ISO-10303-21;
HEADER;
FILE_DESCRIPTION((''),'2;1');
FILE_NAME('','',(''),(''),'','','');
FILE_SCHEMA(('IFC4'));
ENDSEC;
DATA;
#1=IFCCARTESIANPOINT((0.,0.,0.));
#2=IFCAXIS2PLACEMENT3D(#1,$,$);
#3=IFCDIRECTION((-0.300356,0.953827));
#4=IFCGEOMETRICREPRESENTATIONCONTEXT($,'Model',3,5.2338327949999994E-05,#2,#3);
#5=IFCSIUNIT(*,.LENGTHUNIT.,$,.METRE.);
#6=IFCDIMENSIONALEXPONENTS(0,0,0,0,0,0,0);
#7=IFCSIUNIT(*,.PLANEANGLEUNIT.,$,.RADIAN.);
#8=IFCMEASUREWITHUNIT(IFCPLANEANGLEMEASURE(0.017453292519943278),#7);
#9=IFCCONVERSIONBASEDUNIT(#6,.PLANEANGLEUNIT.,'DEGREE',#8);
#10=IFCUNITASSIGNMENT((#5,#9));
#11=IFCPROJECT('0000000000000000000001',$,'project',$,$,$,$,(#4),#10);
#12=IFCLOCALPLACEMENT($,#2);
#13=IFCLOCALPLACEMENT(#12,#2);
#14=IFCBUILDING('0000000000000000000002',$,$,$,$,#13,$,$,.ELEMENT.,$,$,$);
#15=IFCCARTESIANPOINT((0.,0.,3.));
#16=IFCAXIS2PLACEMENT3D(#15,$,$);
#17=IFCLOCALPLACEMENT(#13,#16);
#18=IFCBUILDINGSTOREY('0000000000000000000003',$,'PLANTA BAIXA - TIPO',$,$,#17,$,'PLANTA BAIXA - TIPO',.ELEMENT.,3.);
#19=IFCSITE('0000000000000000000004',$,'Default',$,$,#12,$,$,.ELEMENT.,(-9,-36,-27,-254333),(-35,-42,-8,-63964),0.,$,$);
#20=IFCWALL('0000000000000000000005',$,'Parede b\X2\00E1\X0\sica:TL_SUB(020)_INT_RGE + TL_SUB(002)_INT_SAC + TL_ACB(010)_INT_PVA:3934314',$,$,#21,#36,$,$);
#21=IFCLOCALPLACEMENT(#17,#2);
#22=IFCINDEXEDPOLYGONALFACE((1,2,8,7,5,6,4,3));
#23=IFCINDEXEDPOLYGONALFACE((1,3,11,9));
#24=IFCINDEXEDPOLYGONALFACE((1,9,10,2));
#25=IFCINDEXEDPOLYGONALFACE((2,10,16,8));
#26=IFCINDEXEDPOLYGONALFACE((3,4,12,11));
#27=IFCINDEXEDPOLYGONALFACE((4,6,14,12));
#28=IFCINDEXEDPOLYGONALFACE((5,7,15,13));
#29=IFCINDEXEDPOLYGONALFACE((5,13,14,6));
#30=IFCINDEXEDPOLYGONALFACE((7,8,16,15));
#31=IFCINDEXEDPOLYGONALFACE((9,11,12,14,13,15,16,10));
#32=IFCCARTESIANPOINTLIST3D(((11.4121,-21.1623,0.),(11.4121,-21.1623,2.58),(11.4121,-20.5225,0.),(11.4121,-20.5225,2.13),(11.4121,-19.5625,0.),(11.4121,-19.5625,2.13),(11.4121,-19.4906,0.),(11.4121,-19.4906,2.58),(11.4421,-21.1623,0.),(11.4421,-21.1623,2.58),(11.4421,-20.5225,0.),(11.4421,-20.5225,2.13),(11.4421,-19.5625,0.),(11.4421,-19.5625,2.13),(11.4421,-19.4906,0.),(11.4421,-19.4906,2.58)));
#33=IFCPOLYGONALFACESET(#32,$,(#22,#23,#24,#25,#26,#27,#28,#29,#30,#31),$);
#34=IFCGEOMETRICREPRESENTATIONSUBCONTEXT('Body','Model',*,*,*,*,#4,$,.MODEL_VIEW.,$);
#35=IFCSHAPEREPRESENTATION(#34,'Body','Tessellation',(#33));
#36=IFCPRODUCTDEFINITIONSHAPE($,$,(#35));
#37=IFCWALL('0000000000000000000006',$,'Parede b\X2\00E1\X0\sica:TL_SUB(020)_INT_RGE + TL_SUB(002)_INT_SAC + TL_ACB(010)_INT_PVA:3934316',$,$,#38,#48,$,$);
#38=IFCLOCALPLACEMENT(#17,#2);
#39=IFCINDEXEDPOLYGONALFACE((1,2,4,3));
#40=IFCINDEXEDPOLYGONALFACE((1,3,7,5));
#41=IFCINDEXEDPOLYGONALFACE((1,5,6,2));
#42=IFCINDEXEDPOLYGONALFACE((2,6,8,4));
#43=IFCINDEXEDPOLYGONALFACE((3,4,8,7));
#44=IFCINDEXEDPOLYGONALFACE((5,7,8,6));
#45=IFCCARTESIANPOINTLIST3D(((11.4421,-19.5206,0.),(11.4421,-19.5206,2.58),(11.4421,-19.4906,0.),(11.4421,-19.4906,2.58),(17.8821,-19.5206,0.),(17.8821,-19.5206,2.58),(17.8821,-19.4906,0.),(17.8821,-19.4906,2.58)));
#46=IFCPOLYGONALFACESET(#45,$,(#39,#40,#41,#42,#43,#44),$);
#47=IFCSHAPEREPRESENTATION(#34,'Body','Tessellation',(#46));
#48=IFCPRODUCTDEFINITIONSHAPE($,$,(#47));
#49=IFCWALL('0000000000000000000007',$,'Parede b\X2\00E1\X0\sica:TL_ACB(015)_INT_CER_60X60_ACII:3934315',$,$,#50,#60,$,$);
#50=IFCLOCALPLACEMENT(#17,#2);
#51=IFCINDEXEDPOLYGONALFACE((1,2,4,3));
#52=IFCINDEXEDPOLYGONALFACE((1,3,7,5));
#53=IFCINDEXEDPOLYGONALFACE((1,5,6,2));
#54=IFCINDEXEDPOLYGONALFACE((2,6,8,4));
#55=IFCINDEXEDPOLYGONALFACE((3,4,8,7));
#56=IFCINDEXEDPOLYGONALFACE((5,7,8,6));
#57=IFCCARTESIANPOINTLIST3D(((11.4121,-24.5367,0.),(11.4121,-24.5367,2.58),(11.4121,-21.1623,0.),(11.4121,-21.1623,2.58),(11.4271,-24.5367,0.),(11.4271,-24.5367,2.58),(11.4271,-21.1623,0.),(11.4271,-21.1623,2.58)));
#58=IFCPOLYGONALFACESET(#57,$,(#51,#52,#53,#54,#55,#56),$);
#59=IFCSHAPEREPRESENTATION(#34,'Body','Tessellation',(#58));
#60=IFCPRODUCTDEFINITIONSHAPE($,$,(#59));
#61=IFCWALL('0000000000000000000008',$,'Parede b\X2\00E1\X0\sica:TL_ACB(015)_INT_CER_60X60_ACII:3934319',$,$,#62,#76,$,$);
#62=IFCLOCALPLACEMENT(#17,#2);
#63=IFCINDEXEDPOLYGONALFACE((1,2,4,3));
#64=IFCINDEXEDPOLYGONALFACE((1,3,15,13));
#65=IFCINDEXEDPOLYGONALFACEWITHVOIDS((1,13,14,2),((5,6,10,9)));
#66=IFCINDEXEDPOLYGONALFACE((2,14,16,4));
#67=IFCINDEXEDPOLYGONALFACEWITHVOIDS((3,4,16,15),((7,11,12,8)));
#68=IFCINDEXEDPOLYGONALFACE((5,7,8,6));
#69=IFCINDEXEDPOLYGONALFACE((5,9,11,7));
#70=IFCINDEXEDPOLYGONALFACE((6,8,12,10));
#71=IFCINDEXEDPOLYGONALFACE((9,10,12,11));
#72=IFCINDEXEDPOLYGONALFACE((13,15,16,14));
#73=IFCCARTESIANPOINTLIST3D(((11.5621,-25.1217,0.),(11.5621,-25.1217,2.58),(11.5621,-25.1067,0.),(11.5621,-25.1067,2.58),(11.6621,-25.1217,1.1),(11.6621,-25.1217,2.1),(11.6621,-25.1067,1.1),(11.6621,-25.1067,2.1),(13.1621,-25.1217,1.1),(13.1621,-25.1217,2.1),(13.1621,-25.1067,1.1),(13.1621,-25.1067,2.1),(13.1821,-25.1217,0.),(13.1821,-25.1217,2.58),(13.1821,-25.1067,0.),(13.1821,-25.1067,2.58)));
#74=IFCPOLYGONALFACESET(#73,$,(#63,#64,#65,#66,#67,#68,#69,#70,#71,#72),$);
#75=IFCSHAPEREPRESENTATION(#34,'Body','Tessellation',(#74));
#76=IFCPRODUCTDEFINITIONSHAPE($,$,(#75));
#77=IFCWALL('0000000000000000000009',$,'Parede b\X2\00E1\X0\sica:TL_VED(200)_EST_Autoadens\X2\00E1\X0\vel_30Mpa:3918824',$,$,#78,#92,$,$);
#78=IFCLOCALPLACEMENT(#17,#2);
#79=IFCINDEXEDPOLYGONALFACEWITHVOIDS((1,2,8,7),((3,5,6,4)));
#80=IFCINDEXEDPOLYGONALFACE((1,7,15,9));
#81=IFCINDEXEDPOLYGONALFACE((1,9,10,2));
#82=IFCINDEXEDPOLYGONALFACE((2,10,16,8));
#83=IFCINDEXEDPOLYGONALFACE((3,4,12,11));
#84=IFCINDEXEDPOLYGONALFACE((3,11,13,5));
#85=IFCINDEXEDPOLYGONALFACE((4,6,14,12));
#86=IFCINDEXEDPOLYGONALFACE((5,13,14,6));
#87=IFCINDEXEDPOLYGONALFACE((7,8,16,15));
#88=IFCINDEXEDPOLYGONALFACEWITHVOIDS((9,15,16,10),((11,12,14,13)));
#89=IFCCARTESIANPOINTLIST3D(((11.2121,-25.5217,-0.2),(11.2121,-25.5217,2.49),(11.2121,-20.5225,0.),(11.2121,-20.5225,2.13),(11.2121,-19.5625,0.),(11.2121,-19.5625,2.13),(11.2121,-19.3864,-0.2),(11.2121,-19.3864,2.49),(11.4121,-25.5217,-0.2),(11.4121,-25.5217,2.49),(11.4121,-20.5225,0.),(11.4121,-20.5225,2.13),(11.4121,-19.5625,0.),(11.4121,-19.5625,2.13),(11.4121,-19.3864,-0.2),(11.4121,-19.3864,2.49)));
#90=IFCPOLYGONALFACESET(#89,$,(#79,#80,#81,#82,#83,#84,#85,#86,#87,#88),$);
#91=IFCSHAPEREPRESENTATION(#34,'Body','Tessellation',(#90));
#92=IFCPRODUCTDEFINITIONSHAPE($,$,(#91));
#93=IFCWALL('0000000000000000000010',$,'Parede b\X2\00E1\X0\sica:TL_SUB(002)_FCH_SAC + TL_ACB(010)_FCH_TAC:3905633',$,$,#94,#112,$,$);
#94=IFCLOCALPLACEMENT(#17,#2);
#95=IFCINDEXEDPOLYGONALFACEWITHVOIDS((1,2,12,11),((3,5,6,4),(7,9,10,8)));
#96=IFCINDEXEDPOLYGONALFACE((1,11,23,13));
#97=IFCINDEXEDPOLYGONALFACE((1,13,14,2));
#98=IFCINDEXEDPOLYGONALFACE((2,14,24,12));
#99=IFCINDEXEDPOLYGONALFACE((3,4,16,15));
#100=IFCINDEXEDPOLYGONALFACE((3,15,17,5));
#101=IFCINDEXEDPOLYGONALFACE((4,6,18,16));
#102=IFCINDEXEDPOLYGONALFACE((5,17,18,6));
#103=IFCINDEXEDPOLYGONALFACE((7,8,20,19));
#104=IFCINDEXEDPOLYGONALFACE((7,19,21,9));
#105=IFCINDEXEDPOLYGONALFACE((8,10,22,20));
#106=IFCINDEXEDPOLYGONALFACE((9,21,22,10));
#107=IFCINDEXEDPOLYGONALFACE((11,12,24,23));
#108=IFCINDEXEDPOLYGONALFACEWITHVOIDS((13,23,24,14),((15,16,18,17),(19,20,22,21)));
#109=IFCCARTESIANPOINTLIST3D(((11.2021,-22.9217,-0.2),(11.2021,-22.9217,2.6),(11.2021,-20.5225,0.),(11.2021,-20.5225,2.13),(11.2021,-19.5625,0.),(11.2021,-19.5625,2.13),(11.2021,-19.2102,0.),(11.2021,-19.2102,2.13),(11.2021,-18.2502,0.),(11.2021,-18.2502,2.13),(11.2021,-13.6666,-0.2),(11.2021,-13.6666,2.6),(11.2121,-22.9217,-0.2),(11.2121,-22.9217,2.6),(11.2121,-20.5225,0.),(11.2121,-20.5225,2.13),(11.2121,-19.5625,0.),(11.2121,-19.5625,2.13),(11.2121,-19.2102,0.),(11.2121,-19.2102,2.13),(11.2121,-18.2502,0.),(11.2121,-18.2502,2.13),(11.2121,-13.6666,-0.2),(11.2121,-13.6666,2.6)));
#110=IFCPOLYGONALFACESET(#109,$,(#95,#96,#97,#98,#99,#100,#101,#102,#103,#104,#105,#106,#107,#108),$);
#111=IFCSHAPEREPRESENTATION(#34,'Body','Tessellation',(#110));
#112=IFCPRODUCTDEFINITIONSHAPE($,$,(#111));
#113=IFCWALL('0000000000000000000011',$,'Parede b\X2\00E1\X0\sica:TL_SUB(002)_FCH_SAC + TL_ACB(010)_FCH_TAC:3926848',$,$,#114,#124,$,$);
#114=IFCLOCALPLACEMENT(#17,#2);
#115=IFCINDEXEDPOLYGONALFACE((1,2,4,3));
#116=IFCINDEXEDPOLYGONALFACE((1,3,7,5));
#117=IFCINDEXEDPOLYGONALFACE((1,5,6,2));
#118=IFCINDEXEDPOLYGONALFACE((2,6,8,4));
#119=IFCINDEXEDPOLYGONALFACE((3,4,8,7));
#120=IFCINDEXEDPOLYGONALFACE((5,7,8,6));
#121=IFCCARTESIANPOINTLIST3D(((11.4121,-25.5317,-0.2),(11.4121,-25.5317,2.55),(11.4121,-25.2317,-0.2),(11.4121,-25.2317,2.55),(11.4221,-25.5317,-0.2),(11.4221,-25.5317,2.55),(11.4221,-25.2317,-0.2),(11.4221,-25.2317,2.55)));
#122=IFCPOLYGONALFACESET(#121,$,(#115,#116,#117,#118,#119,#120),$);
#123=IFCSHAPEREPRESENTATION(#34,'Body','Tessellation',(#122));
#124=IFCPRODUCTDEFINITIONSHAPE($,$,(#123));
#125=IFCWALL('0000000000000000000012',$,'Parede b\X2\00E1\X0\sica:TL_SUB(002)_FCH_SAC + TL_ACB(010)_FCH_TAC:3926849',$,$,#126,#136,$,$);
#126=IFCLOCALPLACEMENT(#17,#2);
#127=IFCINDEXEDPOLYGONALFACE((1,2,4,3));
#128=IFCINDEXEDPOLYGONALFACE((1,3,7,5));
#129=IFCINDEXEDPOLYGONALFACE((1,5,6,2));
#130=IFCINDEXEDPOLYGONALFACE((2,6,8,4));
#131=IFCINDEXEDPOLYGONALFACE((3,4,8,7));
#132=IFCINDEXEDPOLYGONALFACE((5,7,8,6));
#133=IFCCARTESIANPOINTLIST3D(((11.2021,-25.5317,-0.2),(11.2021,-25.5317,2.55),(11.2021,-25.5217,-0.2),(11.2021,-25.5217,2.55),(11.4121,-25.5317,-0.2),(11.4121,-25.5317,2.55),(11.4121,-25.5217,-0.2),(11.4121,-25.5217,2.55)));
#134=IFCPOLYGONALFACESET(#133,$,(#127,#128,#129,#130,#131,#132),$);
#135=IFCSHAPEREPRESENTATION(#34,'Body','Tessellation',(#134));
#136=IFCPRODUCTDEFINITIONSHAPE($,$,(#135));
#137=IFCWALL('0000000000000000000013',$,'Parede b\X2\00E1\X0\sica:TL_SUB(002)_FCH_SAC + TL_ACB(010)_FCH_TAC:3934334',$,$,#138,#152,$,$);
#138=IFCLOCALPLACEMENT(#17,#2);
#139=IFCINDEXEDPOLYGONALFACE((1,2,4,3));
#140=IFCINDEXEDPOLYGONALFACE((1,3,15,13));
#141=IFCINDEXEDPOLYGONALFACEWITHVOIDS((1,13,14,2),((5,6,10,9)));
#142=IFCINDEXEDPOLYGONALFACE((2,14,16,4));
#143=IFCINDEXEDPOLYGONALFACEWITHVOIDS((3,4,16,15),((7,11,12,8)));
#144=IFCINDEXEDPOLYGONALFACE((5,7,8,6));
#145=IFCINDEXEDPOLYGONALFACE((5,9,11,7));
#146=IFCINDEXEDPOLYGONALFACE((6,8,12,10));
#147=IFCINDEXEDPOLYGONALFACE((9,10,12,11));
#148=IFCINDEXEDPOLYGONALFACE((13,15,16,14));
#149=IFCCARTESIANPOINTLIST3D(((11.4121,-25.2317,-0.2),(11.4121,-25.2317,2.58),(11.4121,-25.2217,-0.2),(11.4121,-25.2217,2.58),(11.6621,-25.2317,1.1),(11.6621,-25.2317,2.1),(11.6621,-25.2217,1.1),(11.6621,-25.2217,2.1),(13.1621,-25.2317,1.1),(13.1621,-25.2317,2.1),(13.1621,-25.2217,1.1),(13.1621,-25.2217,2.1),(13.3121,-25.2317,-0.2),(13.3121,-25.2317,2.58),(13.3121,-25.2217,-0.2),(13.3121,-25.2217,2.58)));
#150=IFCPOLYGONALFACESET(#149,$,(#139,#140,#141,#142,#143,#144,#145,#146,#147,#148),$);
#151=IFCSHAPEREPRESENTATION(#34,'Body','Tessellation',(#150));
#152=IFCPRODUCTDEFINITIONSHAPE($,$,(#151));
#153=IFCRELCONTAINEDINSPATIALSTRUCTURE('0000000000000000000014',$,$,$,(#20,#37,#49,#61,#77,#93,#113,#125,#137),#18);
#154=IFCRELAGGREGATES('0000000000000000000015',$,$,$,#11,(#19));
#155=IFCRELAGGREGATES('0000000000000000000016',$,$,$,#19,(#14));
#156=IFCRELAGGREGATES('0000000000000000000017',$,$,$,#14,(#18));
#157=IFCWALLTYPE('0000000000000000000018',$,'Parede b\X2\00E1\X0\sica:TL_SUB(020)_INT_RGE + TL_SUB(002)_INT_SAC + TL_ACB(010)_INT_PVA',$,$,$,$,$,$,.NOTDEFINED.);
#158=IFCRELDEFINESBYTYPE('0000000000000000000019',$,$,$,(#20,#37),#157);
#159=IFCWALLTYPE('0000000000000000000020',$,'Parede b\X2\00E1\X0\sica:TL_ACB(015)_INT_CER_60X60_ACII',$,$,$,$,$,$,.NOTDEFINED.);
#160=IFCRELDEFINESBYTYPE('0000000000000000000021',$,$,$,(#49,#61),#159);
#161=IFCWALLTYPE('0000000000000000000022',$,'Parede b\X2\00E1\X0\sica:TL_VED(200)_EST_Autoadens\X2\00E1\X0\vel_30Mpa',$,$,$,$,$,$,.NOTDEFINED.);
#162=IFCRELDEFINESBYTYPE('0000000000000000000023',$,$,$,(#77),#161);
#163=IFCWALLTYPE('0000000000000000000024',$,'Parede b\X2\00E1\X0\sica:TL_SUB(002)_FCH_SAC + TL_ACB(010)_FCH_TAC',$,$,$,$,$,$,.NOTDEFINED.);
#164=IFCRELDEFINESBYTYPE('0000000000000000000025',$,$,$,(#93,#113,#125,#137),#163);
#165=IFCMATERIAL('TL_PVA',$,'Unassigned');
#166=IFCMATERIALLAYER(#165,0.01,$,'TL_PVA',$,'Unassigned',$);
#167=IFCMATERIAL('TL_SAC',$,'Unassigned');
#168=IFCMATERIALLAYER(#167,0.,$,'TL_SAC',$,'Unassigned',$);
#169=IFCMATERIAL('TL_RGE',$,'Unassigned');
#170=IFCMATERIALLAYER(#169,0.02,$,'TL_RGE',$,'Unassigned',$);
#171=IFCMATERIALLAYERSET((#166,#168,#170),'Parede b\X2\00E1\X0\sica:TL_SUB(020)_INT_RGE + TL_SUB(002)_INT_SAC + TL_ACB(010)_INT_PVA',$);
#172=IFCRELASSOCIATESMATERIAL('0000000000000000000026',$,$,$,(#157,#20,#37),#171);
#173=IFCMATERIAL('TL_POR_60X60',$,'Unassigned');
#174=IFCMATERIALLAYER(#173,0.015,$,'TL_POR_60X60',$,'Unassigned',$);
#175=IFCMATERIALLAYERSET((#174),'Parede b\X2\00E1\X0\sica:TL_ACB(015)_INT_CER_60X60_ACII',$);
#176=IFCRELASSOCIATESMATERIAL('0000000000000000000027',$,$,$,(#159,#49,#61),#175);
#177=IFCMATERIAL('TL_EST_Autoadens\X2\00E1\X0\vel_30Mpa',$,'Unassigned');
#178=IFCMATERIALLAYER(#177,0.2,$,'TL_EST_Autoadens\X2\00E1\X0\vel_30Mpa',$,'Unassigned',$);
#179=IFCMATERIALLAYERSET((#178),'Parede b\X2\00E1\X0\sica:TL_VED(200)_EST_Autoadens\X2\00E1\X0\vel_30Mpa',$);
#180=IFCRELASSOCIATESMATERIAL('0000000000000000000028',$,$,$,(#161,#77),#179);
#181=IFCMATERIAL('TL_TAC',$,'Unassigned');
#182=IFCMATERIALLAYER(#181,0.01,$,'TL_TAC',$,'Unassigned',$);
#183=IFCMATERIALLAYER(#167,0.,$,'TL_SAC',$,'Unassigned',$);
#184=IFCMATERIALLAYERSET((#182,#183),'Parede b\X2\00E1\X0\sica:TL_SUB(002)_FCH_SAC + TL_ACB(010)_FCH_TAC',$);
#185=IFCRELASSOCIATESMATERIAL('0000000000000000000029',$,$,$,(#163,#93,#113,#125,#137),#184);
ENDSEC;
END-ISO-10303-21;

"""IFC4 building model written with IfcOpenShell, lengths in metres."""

from ifc_helpers import new_model, entity, si_unit, converted_unit, direction, frame, frame_2d, origin, place, context, subcontext, project, spatial, rectangle, extrude, material, layer, layer_set, layer_usage, type_object, element, save


model = new_model("IFC4")

# Units and contexts
model_context = context("Model", 3, precision=5.2338327949999994e-05, world=origin(), true_north=direction((-0.300356, 0.953827)))
body_context = subcontext(model_context, "Body", "Model", "MODEL_VIEW")
ifc_project = project(units=[si_unit("LENGTHUNIT", "METRE"), converted_unit("PLANEANGLEUNIT", "DEGREE", entity("IfcPlaneAngleMeasure", 0.017453292519943278), si_unit("PLANEANGLEUNIT", "RADIAN"), dimensions=[0, 0, 0, 0, 0, 0, 0])], contexts=[model_context])

# Site, building, storey
site_placement = place(None, origin())
site = spatial("IfcSite", under=ifc_project, at=site_placement, Name="Default", CompositionType="ELEMENT", RefLatitude=(-9, -36, -27, -254333), RefLongitude=(-35, -42, -8, -63964), RefElevation=0.0)
building_placement = place(site_placement, origin())
building = spatial("IfcBuilding", under=site, at=building_placement, CompositionType="ELEMENT")
storey_placement = place(building_placement, frame((0.0, 0.0, 3.0)))
storey = spatial("IfcBuildingStorey", under=building, at=storey_placement, Name="PLANTA BAIXA - TIPO", LongName="PLANTA BAIXA - TIPO", CompositionType="ELEMENT", Elevation=3.0)

# Shared definitions
ifc_material_1 = material(Name="TL_POR_60X60", Category="Unassigned")

# Shared definitions
ifc_material_2 = material(Name="TL_EST_Autoadensável_30Mpa", Category="Unassigned")

# Shared definitions
ifc_material_3 = material(Name="TL_PVA", Category="Unassigned")
ifc_layer_1 = layer(ifc_material_3, 0.01, Name="TL_PVA", Category="Unassigned")
ifc_material_4 = material(Name="TL_SAC", Category="Unassigned")
ifc_layer_2 = layer(ifc_material_4, 0.0, Name="TL_SAC", Category="Unassigned")
ifc_material_5 = material(Name="TL_RGE", Category="Unassigned")
ifc_layer_3 = layer(ifc_material_5, 0.02, Name="TL_RGE", Category="Unassigned")
ifc_layer_set_1 = layer_set([ifc_layer_1, ifc_layer_2, ifc_layer_3], Name="Parede básica:TL_SUB(020)_INT_RGE + TL_SUB(002)_INT_SAC + TL_ACB(010)_INT_PVA")
wall_type_1 = type_object("IfcWallType", Name="Parede básica:TL_SUB(020)_INT_RGE + TL_SUB(002)_INT_SAC + TL_ACB(010)_INT_PVA", PredefinedType="NOTDEFINED", material=ifc_layer_set_1)

# Wall, opening
ifc_layer_usage_1 = layer_usage(ifc_layer_set_1, "AXIS2", "NEGATIVE", 0.015)
wall_1_placement = place(storey_placement, frame((11.4271, -19.4906, 0.0), z_axis=(0.0, 0.0, 1.0), x_axis=(0.0, -1.0, 0.0)))
wall_1 = element("IfcWall", 1, at=wall_1_placement, inside=storey, type_object=wall_type_1, material=ifc_layer_usage_1, Name="Parede básica:TL_SUB(020)_INT_RGE + TL_SUB(002)_INT_SAC + TL_ACB(010)_INT_PVA:3934314", context=body_context, shape_type="SweptSolid", body=[
    extrude(rectangle(XDim=1.6717, YDim=0.03, at=frame_2d((0.8359, 0.0), x_axis=(-1.0, 0.0))), origin(), (0.0, 0.0, 1.0), 2.58),
])
opening_1_placement = place(wall_1_placement, frame((-19.4906, -11.4271, 0.0)))
element("IfcOpeningElement", 2, at=opening_1_placement, cuts=wall_1, PredefinedType="OPENING", context=body_context, shape_type="SweptSolid", body=[
    extrude(rectangle(XDim=2.13, YDim=0.96, at=frame_2d((0.0, 0.0), x_axis=(0.0, 1.0))), frame((20.0425, 9.8881, 1.065), z_axis=(0.0, 1.0, 0.0), x_axis=(-1.0, 0.0, 0.0)), (0.0, 0.0, 1.0), 3.048),
])

# Walls
ifc_layer_usage_2 = layer_usage(ifc_layer_set_1, "AXIS2", "POSITIVE", -0.015)
wall_2_placement = place(storey_placement, frame((11.4421, -19.5056, 0.0)))
element("IfcWall", 3, at=wall_2_placement, inside=storey, type_object=wall_type_1, material=ifc_layer_usage_2, Name="Parede básica:TL_SUB(020)_INT_RGE + TL_SUB(002)_INT_SAC + TL_ACB(010)_INT_PVA:3934316", context=body_context, shape_type="SweptSolid", body=[
    extrude(rectangle(XDim=6.44, YDim=0.03, at=frame_2d((3.22, 0.0), x_axis=(-1.0, 0.0))), origin(), (0.0, 0.0, 1.0), 2.58),
])
ifc_layer_4 = layer(ifc_material_1, 0.015, Name="TL_POR_60X60", Category="Unassigned")
ifc_layer_set_2 = layer_set([ifc_layer_4], Name="Parede básica:TL_ACB(015)_INT_CER_60X60_ACII")
ifc_layer_usage_3 = layer_usage(ifc_layer_set_2, "AXIS2", "NEGATIVE", 0.0075)
wall_type_2 = type_object("IfcWallType", Name="Parede básica:TL_ACB(015)_INT_CER_60X60_ACII", PredefinedType="NOTDEFINED", material=ifc_layer_set_2)
wall_3_placement = place(storey_placement, frame((11.4196, -21.1623, 0.0), z_axis=(0.0, 0.0, 1.0), x_axis=(0.0, -1.0, 0.0)))
element("IfcWall", 4, at=wall_3_placement, inside=storey, type_object=wall_type_2, material=ifc_layer_usage_3, Name="Parede básica:TL_ACB(015)_INT_CER_60X60_ACII:3934315", context=body_context, shape_type="SweptSolid", body=[
    extrude(rectangle(XDim=3.3744, YDim=0.015, at=frame_2d((1.6872, 0.0), x_axis=(-1.0, 0.0))), origin(), (0.0, 0.0, 1.0), 2.58),
])

# Walls, openings
ifc_layer_usage_4 = layer_usage(ifc_layer_set_2, "AXIS2", "NEGATIVE", 0.0075)
wall_4_placement = place(storey_placement, frame((11.5621, -25.1142, 0.0)))
wall_4 = element("IfcWall", 5, at=wall_4_placement, inside=storey, type_object=wall_type_2, material=ifc_layer_usage_4, Name="Parede básica:TL_ACB(015)_INT_CER_60X60_ACII:3934319", context=body_context, shape_type="SweptSolid", body=[
    extrude(rectangle(XDim=1.62, YDim=0.015, at=frame_2d((0.81, 0.0), x_axis=(-1.0, 0.0))), origin(), (0.0, 0.0, 1.0), 2.58),
])
opening_2_placement = place(wall_4_placement, frame((-11.5621, 25.1142, 1.1)))
element("IfcOpeningElement", 6, at=opening_2_placement, cuts=wall_4, PredefinedType="OPENING", context=body_context, shape_type="SweptSolid", body=[
    extrude(rectangle(XDim=1.0, YDim=1.5, at=frame_2d((0.0, 0.0), x_axis=(0.0, 1.0))), frame((12.4121, -26.6457, 0.5), z_axis=(0.0, 1.0, 0.0), x_axis=(1.0, 0.0, 0.0)), (0.0, 0.0, 1.0), 3.048),
])
ifc_layer_5 = layer(ifc_material_2, 0.2, Name="TL_EST_Autoadensável_30Mpa", Category="Unassigned")
ifc_layer_set_3 = layer_set([ifc_layer_5], Name="Parede básica:TL_VED(200)_EST_Autoadensável_30Mpa")
ifc_layer_usage_5 = layer_usage(ifc_layer_set_3, "AXIS2", "NEGATIVE", 0.1)
wall_type_3 = type_object("IfcWallType", Name="Parede básica:TL_VED(200)_EST_Autoadensável_30Mpa", PredefinedType="NOTDEFINED", material=ifc_layer_set_3)
wall_5_placement = place(storey_placement, frame((11.3121, -25.5217, -0.2), z_axis=(0.0, 0.0, 1.0), x_axis=(0.0, 1.0, 0.0)))
wall_5 = element("IfcWall", 7, at=wall_5_placement, inside=storey, type_object=wall_type_3, material=ifc_layer_usage_5, Name="Parede básica:TL_VED(200)_EST_Autoadensável_30Mpa:3918824", context=body_context, shape_type="SweptSolid", body=[
    extrude(rectangle(XDim=6.1354, YDim=0.2, at=frame_2d((3.0677, 0.0), x_axis=(-1.0, 0.0))), origin(), (0.0, 0.0, 1.0), 2.69),
])
opening_3_placement = place(wall_5_placement, frame((5.9592, 0.1, 0.2)))
element("IfcOpeningElement", 8, at=opening_3_placement, cuts=wall_5, PredefinedType="OPENING", context=body_context, shape_type="SweptSolid", body=[
    extrude(rectangle(XDim=2.13, YDim=0.96, at=frame_2d((1.065, 0.48), x_axis=(1.0, 0.0))), frame((0.0, 0.0, 0.0), z_axis=(0.0, -1.0, 0.0), x_axis=(0.0, 0.0, 1.0)), (0.0, 0.0, 1.0), 0.2),
])

# Wall, openings
ifc_material_6 = material(Name="TL_TAC", Category="Unassigned")
ifc_layer_6 = layer(ifc_material_6, 0.01, Name="TL_TAC", Category="Unassigned")
ifc_layer_7 = layer(ifc_material_4, 0.0, Name="TL_SAC", Category="Unassigned")
ifc_layer_set_4 = layer_set([ifc_layer_6, ifc_layer_7], Name="Parede básica:TL_SUB(002)_FCH_SAC + TL_ACB(010)_FCH_TAC")
ifc_layer_usage_6 = layer_usage(ifc_layer_set_4, "AXIS2", "POSITIVE", -0.005)
wall_type_4 = type_object("IfcWallType", Name="Parede básica:TL_SUB(002)_FCH_SAC + TL_ACB(010)_FCH_TAC", PredefinedType="NOTDEFINED", material=ifc_layer_set_4)
wall_6_placement = place(storey_placement, frame((11.2071, -22.9217, -0.2), z_axis=(0.0, 0.0, 1.0), x_axis=(0.0, 1.0, 0.0)))
wall_6 = element("IfcWall", 9, at=wall_6_placement, inside=storey, type_object=wall_type_4, material=ifc_layer_usage_6, Name="Parede básica:TL_SUB(002)_FCH_SAC + TL_ACB(010)_FCH_TAC:3905633", context=body_context, shape_type="SweptSolid", body=[
    extrude(rectangle(XDim=9.2551, YDim=0.01, at=frame_2d((4.6276, 0.0), x_axis=(-1.0, 0.0))), origin(), (0.0, 0.0, 1.0), 2.8),
])
opening_4_placement = place(wall_6_placement, frame((22.9217, 11.2071, 0.2)))
element("IfcOpeningElement", 10, at=opening_4_placement, cuts=wall_6, PredefinedType="OPENING", context=body_context, shape_type="SweptSolid", body=[
    extrude(rectangle(XDim=2.13, YDim=0.96, at=frame_2d((0.0, 0.0), x_axis=(1.0, 0.0))), frame((-20.0425, -12.9361, 1.065), z_axis=(0.0, 1.0, 0.0), x_axis=(0.0, 0.0, 1.0)), (0.0, 0.0, 1.0), 3.048),
])
opening_5_placement = place(wall_6_placement, frame((22.9217, 11.2071, 0.2)))
element("IfcOpeningElement", 11, at=opening_5_placement, cuts=wall_6, PredefinedType="OPENING", context=body_context, shape_type="SweptSolid", body=[
    extrude(rectangle(XDim=2.13, YDim=0.96, at=frame_2d((0.0, 0.0), x_axis=(0.0, 1.0))), frame((-18.7302, -12.9361, 1.065), z_axis=(0.0, 1.0, 0.0), x_axis=(-1.0, 0.0, 0.0)), (0.0, 0.0, 1.0), 3.048),
])

# Walls
ifc_layer_usage_7 = layer_usage(ifc_layer_set_4, "AXIS2", "POSITIVE", -0.005)
wall_7_placement = place(storey_placement, frame((11.4171, -25.2317, -0.2), z_axis=(0.0, 0.0, 1.0), x_axis=(0.0, -1.0, 0.0)))
element("IfcWall", 12, at=wall_7_placement, inside=storey, type_object=wall_type_4, material=ifc_layer_usage_7, Name="Parede básica:TL_SUB(002)_FCH_SAC + TL_ACB(010)_FCH_TAC:3926848", context=body_context, shape_type="SweptSolid", body=[
    extrude(rectangle(XDim=0.3, YDim=0.01, at=frame_2d((0.15, 0.0), x_axis=(-1.0, 0.0))), origin(), (0.0, 0.0, 1.0), 2.75),
])
ifc_layer_usage_8 = layer_usage(ifc_layer_set_4, "AXIS2", "POSITIVE", -0.005)
wall_8_placement = place(storey_placement, frame((11.4121, -25.5267, -0.2), z_axis=(0.0, 0.0, 1.0), x_axis=(-1.0, 0.0, 0.0)))
element("IfcWall", 13, at=wall_8_placement, inside=storey, type_object=wall_type_4, material=ifc_layer_usage_8, Name="Parede básica:TL_SUB(002)_FCH_SAC + TL_ACB(010)_FCH_TAC:3926849", context=body_context, shape_type="SweptSolid", body=[
    extrude(rectangle(XDim=0.21, YDim=0.01, at=frame_2d((0.105, 0.0), x_axis=(-1.0, 0.0))), origin(), (0.0, 0.0, 1.0), 2.75),
])

# Wall, opening
ifc_layer_usage_9 = layer_usage(ifc_layer_set_4, "AXIS2", "NEGATIVE", 0.005)
wall_9_placement = place(storey_placement, frame((11.4121, -25.2267, -0.2)))
wall_9 = element("IfcWall", 14, at=wall_9_placement, inside=storey, type_object=wall_type_4, material=ifc_layer_usage_9, Name="Parede básica:TL_SUB(002)_FCH_SAC + TL_ACB(010)_FCH_TAC:3934334", context=body_context, shape_type="SweptSolid", body=[
    extrude(rectangle(XDim=1.9, YDim=0.01, at=frame_2d((0.95, 0.0), x_axis=(-1.0, 0.0))), origin(), (0.0, 0.0, 1.0), 2.78),
])
opening_6_placement = place(wall_9_placement, frame((-11.4121, 25.2267, 1.3)))
element("IfcOpeningElement", 15, at=opening_6_placement, cuts=wall_9, PredefinedType="OPENING", context=body_context, shape_type="SweptSolid", body=[
    extrude(rectangle(XDim=1.0, YDim=1.5, at=frame_2d((0.0, 0.0), x_axis=(0.0, 1.0))), frame((12.4121, -26.6457, 0.5), z_axis=(0.0, 1.0, 0.0), x_axis=(1.0, 0.0, 0.0)), (0.0, 0.0, 1.0), 3.048),
])

save(model, "model.ifc")
